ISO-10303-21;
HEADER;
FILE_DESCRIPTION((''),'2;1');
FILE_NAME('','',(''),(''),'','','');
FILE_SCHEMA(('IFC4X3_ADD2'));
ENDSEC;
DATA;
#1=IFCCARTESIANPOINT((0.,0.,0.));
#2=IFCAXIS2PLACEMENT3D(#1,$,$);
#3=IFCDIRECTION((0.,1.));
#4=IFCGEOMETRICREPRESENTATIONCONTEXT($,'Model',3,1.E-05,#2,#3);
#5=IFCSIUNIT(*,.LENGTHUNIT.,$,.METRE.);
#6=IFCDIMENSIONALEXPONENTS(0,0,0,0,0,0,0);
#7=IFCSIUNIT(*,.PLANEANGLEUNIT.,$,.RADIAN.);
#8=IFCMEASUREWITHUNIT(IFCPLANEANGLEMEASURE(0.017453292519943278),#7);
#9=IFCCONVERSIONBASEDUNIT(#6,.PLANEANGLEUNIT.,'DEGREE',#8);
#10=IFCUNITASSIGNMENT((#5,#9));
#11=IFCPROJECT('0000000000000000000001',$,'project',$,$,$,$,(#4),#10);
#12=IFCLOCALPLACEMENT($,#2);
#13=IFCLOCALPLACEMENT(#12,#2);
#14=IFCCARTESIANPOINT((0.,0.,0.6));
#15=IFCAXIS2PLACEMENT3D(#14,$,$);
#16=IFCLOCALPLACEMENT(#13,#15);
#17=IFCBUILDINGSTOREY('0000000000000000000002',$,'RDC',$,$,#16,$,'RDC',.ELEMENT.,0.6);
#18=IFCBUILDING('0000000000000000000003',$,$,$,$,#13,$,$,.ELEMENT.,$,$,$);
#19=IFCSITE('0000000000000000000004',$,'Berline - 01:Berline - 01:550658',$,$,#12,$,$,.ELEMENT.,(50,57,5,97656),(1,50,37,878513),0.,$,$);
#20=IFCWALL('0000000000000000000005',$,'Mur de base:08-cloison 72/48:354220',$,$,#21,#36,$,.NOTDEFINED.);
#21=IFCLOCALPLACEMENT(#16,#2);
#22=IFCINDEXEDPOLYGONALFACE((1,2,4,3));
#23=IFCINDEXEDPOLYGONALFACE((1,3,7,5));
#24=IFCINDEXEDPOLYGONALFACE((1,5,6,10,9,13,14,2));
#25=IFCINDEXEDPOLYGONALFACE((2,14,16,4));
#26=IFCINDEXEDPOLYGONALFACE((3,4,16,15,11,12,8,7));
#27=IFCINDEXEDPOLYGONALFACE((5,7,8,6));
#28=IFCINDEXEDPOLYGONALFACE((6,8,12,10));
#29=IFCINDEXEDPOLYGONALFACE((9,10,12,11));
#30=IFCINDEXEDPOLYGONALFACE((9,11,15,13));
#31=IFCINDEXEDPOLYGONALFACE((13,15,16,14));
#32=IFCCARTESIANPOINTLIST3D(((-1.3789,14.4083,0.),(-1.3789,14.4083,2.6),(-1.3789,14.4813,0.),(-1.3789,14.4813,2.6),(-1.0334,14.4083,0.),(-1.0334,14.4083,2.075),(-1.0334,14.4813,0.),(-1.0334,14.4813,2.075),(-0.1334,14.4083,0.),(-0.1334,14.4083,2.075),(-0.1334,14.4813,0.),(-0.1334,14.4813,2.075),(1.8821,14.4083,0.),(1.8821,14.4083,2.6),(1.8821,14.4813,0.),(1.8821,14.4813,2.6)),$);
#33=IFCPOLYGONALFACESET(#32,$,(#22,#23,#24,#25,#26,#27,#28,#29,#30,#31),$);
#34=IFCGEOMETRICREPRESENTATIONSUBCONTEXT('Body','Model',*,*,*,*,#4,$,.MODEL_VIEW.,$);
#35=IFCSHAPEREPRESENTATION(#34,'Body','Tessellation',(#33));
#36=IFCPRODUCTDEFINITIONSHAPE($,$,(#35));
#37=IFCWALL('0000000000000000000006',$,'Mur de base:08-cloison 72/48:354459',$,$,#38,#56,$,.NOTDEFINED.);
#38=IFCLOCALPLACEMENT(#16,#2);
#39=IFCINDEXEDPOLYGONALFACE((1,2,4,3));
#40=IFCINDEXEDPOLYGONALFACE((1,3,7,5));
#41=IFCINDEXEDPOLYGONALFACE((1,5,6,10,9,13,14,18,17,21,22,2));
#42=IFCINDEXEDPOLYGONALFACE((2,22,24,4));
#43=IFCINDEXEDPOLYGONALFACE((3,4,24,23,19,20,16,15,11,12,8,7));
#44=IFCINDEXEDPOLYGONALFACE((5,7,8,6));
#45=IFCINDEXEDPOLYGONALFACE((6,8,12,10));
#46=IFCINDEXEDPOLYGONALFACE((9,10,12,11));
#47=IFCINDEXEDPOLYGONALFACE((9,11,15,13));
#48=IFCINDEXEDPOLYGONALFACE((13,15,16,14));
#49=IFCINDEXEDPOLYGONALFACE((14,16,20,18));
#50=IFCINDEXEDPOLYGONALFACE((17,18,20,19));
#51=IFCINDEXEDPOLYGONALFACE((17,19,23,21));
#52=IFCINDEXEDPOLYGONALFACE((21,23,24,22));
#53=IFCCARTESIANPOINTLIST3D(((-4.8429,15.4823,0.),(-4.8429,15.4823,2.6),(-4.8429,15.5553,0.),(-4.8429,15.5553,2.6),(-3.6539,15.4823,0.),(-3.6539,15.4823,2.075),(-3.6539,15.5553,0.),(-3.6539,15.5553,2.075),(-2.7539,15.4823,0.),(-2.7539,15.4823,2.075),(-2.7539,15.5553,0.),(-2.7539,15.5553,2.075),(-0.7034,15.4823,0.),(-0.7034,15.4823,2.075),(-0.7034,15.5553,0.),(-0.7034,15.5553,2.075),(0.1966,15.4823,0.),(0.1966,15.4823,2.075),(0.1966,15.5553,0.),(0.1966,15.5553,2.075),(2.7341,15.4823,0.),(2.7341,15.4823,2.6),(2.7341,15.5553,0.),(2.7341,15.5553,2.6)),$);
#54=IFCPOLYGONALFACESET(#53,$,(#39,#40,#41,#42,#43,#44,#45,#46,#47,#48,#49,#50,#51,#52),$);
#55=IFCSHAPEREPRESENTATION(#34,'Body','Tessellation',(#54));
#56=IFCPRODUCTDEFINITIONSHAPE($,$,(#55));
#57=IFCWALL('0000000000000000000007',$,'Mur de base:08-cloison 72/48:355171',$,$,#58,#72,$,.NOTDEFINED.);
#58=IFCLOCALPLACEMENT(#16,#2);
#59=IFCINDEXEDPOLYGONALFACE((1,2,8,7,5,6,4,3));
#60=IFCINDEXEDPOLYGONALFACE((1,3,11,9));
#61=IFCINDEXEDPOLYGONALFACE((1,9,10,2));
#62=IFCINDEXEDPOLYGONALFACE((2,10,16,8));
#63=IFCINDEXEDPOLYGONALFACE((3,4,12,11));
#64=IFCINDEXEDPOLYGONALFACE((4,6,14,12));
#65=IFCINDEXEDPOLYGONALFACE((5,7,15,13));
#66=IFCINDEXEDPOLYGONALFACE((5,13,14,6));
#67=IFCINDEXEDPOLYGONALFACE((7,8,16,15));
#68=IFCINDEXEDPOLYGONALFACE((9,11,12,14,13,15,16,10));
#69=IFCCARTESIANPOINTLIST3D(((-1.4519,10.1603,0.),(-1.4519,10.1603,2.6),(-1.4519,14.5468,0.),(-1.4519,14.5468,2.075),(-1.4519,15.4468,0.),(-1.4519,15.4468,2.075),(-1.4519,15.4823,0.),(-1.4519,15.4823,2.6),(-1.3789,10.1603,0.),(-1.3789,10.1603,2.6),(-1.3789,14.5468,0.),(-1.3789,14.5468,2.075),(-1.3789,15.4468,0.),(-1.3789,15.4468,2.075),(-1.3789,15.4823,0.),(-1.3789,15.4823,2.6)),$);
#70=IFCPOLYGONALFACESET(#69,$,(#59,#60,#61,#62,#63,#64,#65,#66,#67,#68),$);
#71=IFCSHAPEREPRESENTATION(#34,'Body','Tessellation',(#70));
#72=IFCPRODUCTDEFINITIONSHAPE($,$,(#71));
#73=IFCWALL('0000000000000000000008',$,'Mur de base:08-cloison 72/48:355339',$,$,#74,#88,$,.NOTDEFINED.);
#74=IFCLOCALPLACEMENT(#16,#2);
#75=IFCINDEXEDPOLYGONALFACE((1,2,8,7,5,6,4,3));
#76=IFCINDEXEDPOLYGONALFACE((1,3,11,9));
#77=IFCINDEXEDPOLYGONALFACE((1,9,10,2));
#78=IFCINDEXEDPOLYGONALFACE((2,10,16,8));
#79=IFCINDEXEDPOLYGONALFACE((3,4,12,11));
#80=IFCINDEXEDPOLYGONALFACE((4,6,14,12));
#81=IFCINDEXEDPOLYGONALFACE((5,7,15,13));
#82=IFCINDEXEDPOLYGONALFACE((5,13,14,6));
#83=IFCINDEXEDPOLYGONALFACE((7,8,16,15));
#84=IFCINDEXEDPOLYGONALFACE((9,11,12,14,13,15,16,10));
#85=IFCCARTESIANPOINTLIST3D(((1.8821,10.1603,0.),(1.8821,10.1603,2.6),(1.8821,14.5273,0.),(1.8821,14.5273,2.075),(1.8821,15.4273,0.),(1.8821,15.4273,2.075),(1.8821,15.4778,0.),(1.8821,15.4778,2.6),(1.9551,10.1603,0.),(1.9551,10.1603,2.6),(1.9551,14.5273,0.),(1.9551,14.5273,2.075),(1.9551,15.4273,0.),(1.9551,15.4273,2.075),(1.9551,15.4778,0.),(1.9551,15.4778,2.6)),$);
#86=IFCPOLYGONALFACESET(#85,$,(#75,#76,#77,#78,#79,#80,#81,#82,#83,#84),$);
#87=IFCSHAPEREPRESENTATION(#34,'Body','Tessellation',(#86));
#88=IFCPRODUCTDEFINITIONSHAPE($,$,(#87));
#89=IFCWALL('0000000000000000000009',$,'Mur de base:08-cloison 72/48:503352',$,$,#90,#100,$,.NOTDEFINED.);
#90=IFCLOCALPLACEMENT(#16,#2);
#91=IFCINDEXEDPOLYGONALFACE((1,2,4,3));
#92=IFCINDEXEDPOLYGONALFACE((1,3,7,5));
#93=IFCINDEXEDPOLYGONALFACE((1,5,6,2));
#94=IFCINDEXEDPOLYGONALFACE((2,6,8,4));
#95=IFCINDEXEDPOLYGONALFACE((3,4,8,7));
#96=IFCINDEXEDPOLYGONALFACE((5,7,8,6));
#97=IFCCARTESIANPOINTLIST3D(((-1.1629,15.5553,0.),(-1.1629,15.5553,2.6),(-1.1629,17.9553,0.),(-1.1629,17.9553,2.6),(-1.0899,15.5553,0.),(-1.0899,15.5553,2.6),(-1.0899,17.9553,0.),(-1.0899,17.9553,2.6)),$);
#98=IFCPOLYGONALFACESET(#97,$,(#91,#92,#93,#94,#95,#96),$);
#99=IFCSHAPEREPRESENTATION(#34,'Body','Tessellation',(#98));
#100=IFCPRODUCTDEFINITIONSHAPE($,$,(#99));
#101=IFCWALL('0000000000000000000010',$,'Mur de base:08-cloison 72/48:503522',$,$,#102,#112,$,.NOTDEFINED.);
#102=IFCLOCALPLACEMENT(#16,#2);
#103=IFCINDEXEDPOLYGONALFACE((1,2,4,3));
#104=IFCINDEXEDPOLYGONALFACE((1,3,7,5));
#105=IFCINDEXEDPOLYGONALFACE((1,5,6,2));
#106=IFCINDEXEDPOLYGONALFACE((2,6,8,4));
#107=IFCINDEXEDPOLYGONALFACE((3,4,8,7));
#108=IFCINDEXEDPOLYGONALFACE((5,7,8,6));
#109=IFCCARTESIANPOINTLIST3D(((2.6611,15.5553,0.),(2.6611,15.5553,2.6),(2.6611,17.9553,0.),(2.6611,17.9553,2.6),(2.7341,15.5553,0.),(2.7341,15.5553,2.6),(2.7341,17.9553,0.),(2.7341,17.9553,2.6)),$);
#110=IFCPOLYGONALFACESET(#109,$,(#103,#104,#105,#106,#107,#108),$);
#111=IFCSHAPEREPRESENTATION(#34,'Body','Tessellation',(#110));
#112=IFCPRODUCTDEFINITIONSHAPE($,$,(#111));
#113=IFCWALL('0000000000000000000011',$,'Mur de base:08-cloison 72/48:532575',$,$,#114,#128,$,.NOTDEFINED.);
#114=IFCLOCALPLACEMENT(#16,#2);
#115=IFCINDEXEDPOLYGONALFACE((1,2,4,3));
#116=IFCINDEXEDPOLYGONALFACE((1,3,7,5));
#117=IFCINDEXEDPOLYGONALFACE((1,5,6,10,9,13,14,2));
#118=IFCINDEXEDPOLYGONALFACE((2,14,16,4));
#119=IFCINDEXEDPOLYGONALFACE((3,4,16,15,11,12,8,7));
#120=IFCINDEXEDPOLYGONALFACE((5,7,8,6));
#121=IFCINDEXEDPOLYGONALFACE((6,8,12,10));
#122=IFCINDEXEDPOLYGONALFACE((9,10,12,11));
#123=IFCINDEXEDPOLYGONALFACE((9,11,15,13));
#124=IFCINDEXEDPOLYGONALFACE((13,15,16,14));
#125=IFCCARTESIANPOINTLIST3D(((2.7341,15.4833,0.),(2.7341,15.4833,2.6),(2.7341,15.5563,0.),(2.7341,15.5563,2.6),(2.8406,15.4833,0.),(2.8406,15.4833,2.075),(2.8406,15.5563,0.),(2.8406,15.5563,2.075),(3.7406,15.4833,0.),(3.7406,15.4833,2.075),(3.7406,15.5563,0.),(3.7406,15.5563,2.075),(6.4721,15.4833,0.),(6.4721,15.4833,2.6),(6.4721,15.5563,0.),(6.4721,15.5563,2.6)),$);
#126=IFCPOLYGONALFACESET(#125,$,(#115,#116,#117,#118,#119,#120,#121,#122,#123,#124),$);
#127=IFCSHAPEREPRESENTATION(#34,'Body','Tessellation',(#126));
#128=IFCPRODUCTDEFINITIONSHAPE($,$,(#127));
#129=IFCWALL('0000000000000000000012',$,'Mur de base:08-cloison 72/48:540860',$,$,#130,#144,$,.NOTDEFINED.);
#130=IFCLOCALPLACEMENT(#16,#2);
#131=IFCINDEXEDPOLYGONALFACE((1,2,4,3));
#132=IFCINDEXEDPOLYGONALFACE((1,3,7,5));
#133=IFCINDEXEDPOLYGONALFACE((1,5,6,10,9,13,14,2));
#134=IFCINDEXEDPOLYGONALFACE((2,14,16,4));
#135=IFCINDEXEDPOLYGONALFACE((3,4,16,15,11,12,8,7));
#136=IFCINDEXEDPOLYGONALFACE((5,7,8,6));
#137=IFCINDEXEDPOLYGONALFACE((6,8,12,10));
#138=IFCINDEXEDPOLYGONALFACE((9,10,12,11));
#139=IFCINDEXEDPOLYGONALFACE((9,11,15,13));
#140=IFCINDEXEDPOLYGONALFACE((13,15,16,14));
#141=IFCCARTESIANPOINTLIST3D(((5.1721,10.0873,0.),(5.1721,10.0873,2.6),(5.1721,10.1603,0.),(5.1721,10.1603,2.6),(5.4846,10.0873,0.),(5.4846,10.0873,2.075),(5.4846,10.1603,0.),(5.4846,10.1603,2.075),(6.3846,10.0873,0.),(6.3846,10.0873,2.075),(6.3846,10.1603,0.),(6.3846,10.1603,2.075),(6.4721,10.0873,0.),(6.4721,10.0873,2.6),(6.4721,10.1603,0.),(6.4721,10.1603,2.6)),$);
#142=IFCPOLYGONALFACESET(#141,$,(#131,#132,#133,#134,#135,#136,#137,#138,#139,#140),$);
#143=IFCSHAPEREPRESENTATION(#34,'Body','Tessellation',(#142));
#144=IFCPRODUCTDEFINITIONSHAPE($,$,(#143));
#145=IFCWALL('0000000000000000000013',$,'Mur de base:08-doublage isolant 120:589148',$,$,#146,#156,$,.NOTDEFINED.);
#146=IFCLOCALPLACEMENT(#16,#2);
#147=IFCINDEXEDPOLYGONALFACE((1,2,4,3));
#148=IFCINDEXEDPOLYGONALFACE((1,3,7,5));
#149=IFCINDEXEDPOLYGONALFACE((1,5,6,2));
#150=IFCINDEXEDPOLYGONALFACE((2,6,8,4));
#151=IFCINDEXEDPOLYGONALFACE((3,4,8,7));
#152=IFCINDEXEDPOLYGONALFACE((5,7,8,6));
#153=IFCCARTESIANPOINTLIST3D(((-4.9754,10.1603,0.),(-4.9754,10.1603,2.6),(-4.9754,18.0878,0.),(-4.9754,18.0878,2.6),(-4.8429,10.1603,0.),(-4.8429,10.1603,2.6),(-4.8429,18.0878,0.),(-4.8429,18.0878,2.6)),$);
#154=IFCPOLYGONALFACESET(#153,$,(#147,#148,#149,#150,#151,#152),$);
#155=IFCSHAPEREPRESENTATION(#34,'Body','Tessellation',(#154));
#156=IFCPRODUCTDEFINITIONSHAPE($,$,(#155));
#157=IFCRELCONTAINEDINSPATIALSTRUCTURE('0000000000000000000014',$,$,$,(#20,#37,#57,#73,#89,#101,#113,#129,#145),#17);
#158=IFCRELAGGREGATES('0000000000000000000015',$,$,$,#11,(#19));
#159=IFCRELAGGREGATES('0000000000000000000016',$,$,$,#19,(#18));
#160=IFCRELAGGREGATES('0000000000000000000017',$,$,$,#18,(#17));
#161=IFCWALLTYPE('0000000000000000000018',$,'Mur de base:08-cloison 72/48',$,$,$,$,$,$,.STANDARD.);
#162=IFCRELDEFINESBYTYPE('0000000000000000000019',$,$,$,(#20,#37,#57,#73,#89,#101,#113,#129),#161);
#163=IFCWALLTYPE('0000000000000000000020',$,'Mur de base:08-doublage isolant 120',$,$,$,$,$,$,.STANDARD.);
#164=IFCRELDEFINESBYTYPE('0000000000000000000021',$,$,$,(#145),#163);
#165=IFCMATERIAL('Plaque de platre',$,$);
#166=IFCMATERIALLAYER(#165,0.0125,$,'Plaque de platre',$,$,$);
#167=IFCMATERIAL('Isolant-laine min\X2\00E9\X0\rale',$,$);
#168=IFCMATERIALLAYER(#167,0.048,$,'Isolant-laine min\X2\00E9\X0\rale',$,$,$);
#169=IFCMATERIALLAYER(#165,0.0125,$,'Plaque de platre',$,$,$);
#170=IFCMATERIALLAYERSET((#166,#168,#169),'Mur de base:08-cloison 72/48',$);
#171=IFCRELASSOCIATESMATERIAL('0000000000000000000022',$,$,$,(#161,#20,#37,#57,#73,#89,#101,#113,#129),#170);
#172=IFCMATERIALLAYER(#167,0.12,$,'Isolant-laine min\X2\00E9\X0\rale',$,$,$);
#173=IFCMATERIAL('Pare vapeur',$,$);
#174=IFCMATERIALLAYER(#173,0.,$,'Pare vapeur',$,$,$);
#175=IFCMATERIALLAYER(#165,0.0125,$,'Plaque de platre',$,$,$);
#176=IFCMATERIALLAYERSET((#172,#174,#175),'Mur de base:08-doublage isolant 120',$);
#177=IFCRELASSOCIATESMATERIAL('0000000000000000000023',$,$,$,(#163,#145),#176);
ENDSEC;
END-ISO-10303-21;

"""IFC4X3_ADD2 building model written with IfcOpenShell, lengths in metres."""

from ifc_helpers import new_model, entity, si_unit, converted_unit, direction, frame, frame_2d, origin, place, context, subcontext, project, spatial, rectangle, extrude, material, layer, layer_set, type_object, element, save


model = new_model("IFC4X3_ADD2")

# Units and contexts
model_context = context("Model", 3, precision=1e-05, world=origin(), true_north=direction((0.0, 1.0)))
body_context = subcontext(model_context, "Body", "Model", "MODEL_VIEW")
ifc_project = project(units=[si_unit("LENGTHUNIT", "METRE"), converted_unit("PLANEANGLEUNIT", "DEGREE", entity("IfcPlaneAngleMeasure", 0.017453292519943278), si_unit("PLANEANGLEUNIT", "RADIAN"), dimensions=[0, 0, 0, 0, 0, 0, 0])], contexts=[model_context])

# Site, building, storey
site_placement = place(None, origin())
site = spatial("IfcSite", under=ifc_project, at=site_placement, Name="Berline - 01:Berline - 01:550658", CompositionType="ELEMENT", RefLatitude=(50, 57, 5, 97656), RefLongitude=(1, 50, 37, 878513), RefElevation=0.0)
building_placement = place(site_placement, origin())
building = spatial("IfcBuilding", under=site, at=building_placement, CompositionType="ELEMENT")
storey_placement = place(building_placement, frame((0.0, 0.0, 0.6)))
storey = spatial("IfcBuildingStorey", under=building, at=storey_placement, Name="RDC", LongName="RDC", CompositionType="ELEMENT", Elevation=0.6)

# Wall, opening
ifc_material_1 = material(Name="Plaque de platre")
ifc_layer_1 = layer(ifc_material_1, 0.0125, Name="Plaque de platre")
ifc_material_2 = material(Name="Isolant-laine minérale")
ifc_layer_2 = layer(ifc_material_2, 0.048, Name="Isolant-laine minérale")
ifc_layer_3 = layer(ifc_material_1, 0.0125, Name="Plaque de platre")
ifc_layer_set_1 = layer_set([ifc_layer_1, ifc_layer_2, ifc_layer_3], Name="Mur de base:08-cloison 72/48")
wall_type_1 = type_object("IfcWallType", Name="Mur de base:08-cloison 72/48", PredefinedType="STANDARD", material=ifc_layer_set_1)
wall_1_placement = place(storey_placement, frame((1.8821, 14.4448, 0.0), z_axis=(0.0, 0.0, 1.0), x_axis=(-1.0, 0.0, 0.0)))
wall_1 = element("IfcWall", 1, at=wall_1_placement, inside=storey, type_object=wall_type_1, material=ifc_layer_set_1, Name="Mur de base:08-cloison 72/48:354220", PredefinedType="NOTDEFINED", context=body_context, shape_type="SweptSolid", body=[
    extrude(rectangle(XDim=3.261, YDim=0.073, at=frame_2d((1.6305, 0.0), x_axis=(1.0, 0.0))), origin(), (0.0, 0.0, 1.0), 2.6),
])
opening_1_placement = place(wall_1_placement, frame((2.0155, -0.0365, 0.0)))
element("IfcOpeningElement", 2, at=opening_1_placement, cuts=wall_1, PredefinedType="OPENING", context=body_context, shape_type="SweptSolid", body=[
    extrude(rectangle(XDim=2.075, YDim=0.9, at=frame_2d((1.0375, 0.45), x_axis=(1.0, 0.0))), frame((0.0, 0.0, 0.0), z_axis=(0.0, 1.0, 0.0), x_axis=(0.0, 0.0, 1.0)), (0.0, 0.0, 1.0), 0.073),
])

# Wall, openings
wall_2_placement = place(storey_placement, frame((2.7341, 15.5188, 0.0), z_axis=(0.0, 0.0, 1.0), x_axis=(-1.0, 0.0, 0.0)))
wall_2 = element("IfcWall", 3, at=wall_2_placement, inside=storey, type_object=wall_type_1, material=ifc_layer_set_1, Name="Mur de base:08-cloison 72/48:354459", PredefinedType="NOTDEFINED", context=body_context, shape_type="SweptSolid", body=[
    extrude(rectangle(XDim=7.577, YDim=0.073, at=frame_2d((3.7885, 0.0), x_axis=(1.0, 0.0))), origin(), (0.0, 0.0, 1.0), 2.6),
])
opening_2_placement = place(wall_2_placement, frame((3.4375, 0.0365, 0.0)))
element("IfcOpeningElement", 4, at=opening_2_placement, cuts=wall_2, PredefinedType="OPENING", context=body_context, shape_type="SweptSolid", body=[
    extrude(rectangle(XDim=2.075, YDim=0.9, at=frame_2d((1.0375, 0.45), x_axis=(1.0, 0.0))), frame((0.0, 0.0, 0.0), z_axis=(0.0, -1.0, 0.0), x_axis=(0.0, 0.0, 1.0)), (0.0, 0.0, 1.0), 0.073),
])
opening_3_placement = place(wall_2_placement, frame((6.388, 0.0365, 0.0)))
element("IfcOpeningElement", 5, at=opening_3_placement, cuts=wall_2, PredefinedType="OPENING", context=body_context, shape_type="SweptSolid", body=[
    extrude(rectangle(XDim=2.075, YDim=0.9, at=frame_2d((1.0375, 0.45), x_axis=(1.0, 0.0))), frame((0.0, 0.0, 0.0), z_axis=(0.0, -1.0, 0.0), x_axis=(0.0, 0.0, 1.0)), (0.0, 0.0, 1.0), 0.073),
])

# Walls, openings
wall_3_placement = place(storey_placement, frame((-1.4154, 15.4823, 0.0), z_axis=(0.0, 0.0, 1.0), x_axis=(0.0, -1.0, 0.0)))
wall_3 = element("IfcWall", 6, at=wall_3_placement, inside=storey, type_object=wall_type_1, material=ifc_layer_set_1, Name="Mur de base:08-cloison 72/48:355171", PredefinedType="NOTDEFINED", context=body_context, shape_type="SweptSolid", body=[
    extrude(rectangle(XDim=5.322, YDim=0.073, at=frame_2d((2.661, 0.0), x_axis=(1.0, 0.0))), origin(), (0.0, 0.0, 1.0), 2.6),
])
opening_4_placement = place(wall_3_placement, frame((0.9355, 0.0365, 0.0)))
element("IfcOpeningElement", 7, at=opening_4_placement, cuts=wall_3, PredefinedType="OPENING", context=body_context, shape_type="SweptSolid", body=[
    extrude(rectangle(XDim=2.075, YDim=0.9, at=frame_2d((1.0375, 0.45), x_axis=(1.0, 0.0))), frame((0.0, 0.0, 0.0), z_axis=(0.0, -1.0, 0.0), x_axis=(0.0, 0.0, 1.0)), (0.0, 0.0, 1.0), 0.073),
])
wall_4_placement = place(storey_placement, frame((1.9186, 10.1603, 0.0), z_axis=(0.0, 0.0, 1.0), x_axis=(0.0, 1.0, 0.0)))
wall_4 = element("IfcWall", 8, at=wall_4_placement, inside=storey, type_object=wall_type_1, material=ifc_layer_set_1, Name="Mur de base:08-cloison 72/48:355339", PredefinedType="NOTDEFINED", context=body_context, shape_type="SweptSolid", body=[
    extrude(rectangle(XDim=5.3175, YDim=0.073, at=frame_2d((2.6588, 0.0), x_axis=(-1.0, 0.0))), origin(), (0.0, 0.0, 1.0), 2.6),
])
opening_5_placement = place(wall_4_placement, frame((4.367, -0.0365, 0.0)))
element("IfcOpeningElement", 9, at=opening_5_placement, cuts=wall_4, PredefinedType="OPENING", context=body_context, shape_type="SweptSolid", body=[
    extrude(rectangle(XDim=2.075, YDim=0.9, at=frame_2d((1.0375, 0.45), x_axis=(1.0, 0.0))), frame((0.0, 0.0, 0.0), z_axis=(0.0, 1.0, 0.0), x_axis=(0.0, 0.0, 1.0)), (0.0, 0.0, 1.0), 0.073),
])

# Walls
wall_5_placement = place(storey_placement, frame((-1.1264, 17.9553, 0.0), z_axis=(0.0, 0.0, 1.0), x_axis=(0.0, -1.0, 0.0)))
element("IfcWall", 10, at=wall_5_placement, inside=storey, type_object=wall_type_1, material=ifc_layer_set_1, Name="Mur de base:08-cloison 72/48:503352", PredefinedType="NOTDEFINED", context=body_context, shape_type="SweptSolid", body=[
    extrude(rectangle(XDim=2.4, YDim=0.073, at=frame_2d((1.2, 0.0), x_axis=(-1.0, 0.0))), origin(), (0.0, 0.0, 1.0), 2.6),
])
wall_6_placement = place(storey_placement, frame((2.6976, 17.9553, 0.0), z_axis=(0.0, 0.0, 1.0), x_axis=(0.0, -1.0, 0.0)))
element("IfcWall", 11, at=wall_6_placement, inside=storey, type_object=wall_type_1, material=ifc_layer_set_1, Name="Mur de base:08-cloison 72/48:503522", PredefinedType="NOTDEFINED", context=body_context, shape_type="SweptSolid", body=[
    extrude(rectangle(XDim=2.4, YDim=0.073, at=frame_2d((1.2, 0.0), x_axis=(-1.0, 0.0))), origin(), (0.0, 0.0, 1.0), 2.6),
])

# Walls, openings
wall_7_placement = place(storey_placement, frame((2.7341, 15.5198, 0.0)))
wall_7 = element("IfcWall", 12, at=wall_7_placement, inside=storey, type_object=wall_type_1, material=ifc_layer_set_1, Name="Mur de base:08-cloison 72/48:532575", PredefinedType="NOTDEFINED", context=body_context, shape_type="SweptSolid", body=[
    extrude(rectangle(XDim=3.738, YDim=0.073, at=frame_2d((1.869, 0.0), x_axis=(1.0, 0.0))), origin(), (0.0, 0.0, 1.0), 2.6),
])
opening_6_placement = place(wall_7_placement, frame((0.1065, -0.0365, 0.0)))
element("IfcOpeningElement", 13, at=opening_6_placement, cuts=wall_7, PredefinedType="OPENING", context=body_context, shape_type="SweptSolid", body=[
    extrude(rectangle(XDim=2.075, YDim=0.9, at=frame_2d((1.0375, 0.45), x_axis=(1.0, 0.0))), frame((0.0, 0.0, 0.0), z_axis=(0.0, 1.0, 0.0), x_axis=(0.0, 0.0, 1.0)), (0.0, 0.0, 1.0), 0.073),
])
wall_8_placement = place(storey_placement, frame((5.1721, 10.1238, 0.0)))
wall_8 = element("IfcWall", 14, at=wall_8_placement, inside=storey, type_object=wall_type_1, material=ifc_layer_set_1, Name="Mur de base:08-cloison 72/48:540860", PredefinedType="NOTDEFINED", context=body_context, shape_type="SweptSolid", body=[
    extrude(rectangle(XDim=1.3, YDim=0.073, at=frame_2d((0.65, 0.0), x_axis=(-1.0, 0.0))), origin(), (0.0, 0.0, 1.0), 2.6),
])
opening_7_placement = place(wall_8_placement, frame((0.3125, -0.0365, 0.0)))
element("IfcOpeningElement", 15, at=opening_7_placement, cuts=wall_8, PredefinedType="OPENING", context=body_context, shape_type="SweptSolid", body=[
    extrude(rectangle(XDim=2.075, YDim=0.9, at=frame_2d((1.0375, 0.45), x_axis=(1.0, 0.0))), frame((0.0, 0.0, 0.0), z_axis=(0.0, 1.0, 0.0), x_axis=(0.0, 0.0, 1.0)), (0.0, 0.0, 1.0), 0.073),
])

# Wall
ifc_layer_4 = layer(ifc_material_2, 0.12, Name="Isolant-laine minérale")
ifc_material_3 = material(Name="Pare vapeur")
ifc_layer_5 = layer(ifc_material_3, 0.0, Name="Pare vapeur")
ifc_layer_6 = layer(ifc_material_1, 0.0125, Name="Plaque de platre")
ifc_layer_set_2 = layer_set([ifc_layer_4, ifc_layer_5, ifc_layer_6], Name="Mur de base:08-doublage isolant 120")
wall_type_2 = type_object("IfcWallType", Name="Mur de base:08-doublage isolant 120", PredefinedType="STANDARD", material=ifc_layer_set_2)
wall_9_placement = place(storey_placement, frame((-4.9092, 10.1603, 0.0), z_axis=(0.0, 0.0, 1.0), x_axis=(0.0, 1.0, 0.0)))
element("IfcWall", 16, at=wall_9_placement, inside=storey, type_object=wall_type_2, material=ifc_layer_set_2, Name="Mur de base:08-doublage isolant 120:589148", PredefinedType="NOTDEFINED", context=body_context, shape_type="SweptSolid", body=[
    extrude(rectangle(XDim=7.9275, YDim=0.1325, at=frame_2d((3.9637, 0.0), x_axis=(-1.0, 0.0))), origin(), (0.0, 0.0, 1.0), 2.6),
])

save(model, "model.ifc")
